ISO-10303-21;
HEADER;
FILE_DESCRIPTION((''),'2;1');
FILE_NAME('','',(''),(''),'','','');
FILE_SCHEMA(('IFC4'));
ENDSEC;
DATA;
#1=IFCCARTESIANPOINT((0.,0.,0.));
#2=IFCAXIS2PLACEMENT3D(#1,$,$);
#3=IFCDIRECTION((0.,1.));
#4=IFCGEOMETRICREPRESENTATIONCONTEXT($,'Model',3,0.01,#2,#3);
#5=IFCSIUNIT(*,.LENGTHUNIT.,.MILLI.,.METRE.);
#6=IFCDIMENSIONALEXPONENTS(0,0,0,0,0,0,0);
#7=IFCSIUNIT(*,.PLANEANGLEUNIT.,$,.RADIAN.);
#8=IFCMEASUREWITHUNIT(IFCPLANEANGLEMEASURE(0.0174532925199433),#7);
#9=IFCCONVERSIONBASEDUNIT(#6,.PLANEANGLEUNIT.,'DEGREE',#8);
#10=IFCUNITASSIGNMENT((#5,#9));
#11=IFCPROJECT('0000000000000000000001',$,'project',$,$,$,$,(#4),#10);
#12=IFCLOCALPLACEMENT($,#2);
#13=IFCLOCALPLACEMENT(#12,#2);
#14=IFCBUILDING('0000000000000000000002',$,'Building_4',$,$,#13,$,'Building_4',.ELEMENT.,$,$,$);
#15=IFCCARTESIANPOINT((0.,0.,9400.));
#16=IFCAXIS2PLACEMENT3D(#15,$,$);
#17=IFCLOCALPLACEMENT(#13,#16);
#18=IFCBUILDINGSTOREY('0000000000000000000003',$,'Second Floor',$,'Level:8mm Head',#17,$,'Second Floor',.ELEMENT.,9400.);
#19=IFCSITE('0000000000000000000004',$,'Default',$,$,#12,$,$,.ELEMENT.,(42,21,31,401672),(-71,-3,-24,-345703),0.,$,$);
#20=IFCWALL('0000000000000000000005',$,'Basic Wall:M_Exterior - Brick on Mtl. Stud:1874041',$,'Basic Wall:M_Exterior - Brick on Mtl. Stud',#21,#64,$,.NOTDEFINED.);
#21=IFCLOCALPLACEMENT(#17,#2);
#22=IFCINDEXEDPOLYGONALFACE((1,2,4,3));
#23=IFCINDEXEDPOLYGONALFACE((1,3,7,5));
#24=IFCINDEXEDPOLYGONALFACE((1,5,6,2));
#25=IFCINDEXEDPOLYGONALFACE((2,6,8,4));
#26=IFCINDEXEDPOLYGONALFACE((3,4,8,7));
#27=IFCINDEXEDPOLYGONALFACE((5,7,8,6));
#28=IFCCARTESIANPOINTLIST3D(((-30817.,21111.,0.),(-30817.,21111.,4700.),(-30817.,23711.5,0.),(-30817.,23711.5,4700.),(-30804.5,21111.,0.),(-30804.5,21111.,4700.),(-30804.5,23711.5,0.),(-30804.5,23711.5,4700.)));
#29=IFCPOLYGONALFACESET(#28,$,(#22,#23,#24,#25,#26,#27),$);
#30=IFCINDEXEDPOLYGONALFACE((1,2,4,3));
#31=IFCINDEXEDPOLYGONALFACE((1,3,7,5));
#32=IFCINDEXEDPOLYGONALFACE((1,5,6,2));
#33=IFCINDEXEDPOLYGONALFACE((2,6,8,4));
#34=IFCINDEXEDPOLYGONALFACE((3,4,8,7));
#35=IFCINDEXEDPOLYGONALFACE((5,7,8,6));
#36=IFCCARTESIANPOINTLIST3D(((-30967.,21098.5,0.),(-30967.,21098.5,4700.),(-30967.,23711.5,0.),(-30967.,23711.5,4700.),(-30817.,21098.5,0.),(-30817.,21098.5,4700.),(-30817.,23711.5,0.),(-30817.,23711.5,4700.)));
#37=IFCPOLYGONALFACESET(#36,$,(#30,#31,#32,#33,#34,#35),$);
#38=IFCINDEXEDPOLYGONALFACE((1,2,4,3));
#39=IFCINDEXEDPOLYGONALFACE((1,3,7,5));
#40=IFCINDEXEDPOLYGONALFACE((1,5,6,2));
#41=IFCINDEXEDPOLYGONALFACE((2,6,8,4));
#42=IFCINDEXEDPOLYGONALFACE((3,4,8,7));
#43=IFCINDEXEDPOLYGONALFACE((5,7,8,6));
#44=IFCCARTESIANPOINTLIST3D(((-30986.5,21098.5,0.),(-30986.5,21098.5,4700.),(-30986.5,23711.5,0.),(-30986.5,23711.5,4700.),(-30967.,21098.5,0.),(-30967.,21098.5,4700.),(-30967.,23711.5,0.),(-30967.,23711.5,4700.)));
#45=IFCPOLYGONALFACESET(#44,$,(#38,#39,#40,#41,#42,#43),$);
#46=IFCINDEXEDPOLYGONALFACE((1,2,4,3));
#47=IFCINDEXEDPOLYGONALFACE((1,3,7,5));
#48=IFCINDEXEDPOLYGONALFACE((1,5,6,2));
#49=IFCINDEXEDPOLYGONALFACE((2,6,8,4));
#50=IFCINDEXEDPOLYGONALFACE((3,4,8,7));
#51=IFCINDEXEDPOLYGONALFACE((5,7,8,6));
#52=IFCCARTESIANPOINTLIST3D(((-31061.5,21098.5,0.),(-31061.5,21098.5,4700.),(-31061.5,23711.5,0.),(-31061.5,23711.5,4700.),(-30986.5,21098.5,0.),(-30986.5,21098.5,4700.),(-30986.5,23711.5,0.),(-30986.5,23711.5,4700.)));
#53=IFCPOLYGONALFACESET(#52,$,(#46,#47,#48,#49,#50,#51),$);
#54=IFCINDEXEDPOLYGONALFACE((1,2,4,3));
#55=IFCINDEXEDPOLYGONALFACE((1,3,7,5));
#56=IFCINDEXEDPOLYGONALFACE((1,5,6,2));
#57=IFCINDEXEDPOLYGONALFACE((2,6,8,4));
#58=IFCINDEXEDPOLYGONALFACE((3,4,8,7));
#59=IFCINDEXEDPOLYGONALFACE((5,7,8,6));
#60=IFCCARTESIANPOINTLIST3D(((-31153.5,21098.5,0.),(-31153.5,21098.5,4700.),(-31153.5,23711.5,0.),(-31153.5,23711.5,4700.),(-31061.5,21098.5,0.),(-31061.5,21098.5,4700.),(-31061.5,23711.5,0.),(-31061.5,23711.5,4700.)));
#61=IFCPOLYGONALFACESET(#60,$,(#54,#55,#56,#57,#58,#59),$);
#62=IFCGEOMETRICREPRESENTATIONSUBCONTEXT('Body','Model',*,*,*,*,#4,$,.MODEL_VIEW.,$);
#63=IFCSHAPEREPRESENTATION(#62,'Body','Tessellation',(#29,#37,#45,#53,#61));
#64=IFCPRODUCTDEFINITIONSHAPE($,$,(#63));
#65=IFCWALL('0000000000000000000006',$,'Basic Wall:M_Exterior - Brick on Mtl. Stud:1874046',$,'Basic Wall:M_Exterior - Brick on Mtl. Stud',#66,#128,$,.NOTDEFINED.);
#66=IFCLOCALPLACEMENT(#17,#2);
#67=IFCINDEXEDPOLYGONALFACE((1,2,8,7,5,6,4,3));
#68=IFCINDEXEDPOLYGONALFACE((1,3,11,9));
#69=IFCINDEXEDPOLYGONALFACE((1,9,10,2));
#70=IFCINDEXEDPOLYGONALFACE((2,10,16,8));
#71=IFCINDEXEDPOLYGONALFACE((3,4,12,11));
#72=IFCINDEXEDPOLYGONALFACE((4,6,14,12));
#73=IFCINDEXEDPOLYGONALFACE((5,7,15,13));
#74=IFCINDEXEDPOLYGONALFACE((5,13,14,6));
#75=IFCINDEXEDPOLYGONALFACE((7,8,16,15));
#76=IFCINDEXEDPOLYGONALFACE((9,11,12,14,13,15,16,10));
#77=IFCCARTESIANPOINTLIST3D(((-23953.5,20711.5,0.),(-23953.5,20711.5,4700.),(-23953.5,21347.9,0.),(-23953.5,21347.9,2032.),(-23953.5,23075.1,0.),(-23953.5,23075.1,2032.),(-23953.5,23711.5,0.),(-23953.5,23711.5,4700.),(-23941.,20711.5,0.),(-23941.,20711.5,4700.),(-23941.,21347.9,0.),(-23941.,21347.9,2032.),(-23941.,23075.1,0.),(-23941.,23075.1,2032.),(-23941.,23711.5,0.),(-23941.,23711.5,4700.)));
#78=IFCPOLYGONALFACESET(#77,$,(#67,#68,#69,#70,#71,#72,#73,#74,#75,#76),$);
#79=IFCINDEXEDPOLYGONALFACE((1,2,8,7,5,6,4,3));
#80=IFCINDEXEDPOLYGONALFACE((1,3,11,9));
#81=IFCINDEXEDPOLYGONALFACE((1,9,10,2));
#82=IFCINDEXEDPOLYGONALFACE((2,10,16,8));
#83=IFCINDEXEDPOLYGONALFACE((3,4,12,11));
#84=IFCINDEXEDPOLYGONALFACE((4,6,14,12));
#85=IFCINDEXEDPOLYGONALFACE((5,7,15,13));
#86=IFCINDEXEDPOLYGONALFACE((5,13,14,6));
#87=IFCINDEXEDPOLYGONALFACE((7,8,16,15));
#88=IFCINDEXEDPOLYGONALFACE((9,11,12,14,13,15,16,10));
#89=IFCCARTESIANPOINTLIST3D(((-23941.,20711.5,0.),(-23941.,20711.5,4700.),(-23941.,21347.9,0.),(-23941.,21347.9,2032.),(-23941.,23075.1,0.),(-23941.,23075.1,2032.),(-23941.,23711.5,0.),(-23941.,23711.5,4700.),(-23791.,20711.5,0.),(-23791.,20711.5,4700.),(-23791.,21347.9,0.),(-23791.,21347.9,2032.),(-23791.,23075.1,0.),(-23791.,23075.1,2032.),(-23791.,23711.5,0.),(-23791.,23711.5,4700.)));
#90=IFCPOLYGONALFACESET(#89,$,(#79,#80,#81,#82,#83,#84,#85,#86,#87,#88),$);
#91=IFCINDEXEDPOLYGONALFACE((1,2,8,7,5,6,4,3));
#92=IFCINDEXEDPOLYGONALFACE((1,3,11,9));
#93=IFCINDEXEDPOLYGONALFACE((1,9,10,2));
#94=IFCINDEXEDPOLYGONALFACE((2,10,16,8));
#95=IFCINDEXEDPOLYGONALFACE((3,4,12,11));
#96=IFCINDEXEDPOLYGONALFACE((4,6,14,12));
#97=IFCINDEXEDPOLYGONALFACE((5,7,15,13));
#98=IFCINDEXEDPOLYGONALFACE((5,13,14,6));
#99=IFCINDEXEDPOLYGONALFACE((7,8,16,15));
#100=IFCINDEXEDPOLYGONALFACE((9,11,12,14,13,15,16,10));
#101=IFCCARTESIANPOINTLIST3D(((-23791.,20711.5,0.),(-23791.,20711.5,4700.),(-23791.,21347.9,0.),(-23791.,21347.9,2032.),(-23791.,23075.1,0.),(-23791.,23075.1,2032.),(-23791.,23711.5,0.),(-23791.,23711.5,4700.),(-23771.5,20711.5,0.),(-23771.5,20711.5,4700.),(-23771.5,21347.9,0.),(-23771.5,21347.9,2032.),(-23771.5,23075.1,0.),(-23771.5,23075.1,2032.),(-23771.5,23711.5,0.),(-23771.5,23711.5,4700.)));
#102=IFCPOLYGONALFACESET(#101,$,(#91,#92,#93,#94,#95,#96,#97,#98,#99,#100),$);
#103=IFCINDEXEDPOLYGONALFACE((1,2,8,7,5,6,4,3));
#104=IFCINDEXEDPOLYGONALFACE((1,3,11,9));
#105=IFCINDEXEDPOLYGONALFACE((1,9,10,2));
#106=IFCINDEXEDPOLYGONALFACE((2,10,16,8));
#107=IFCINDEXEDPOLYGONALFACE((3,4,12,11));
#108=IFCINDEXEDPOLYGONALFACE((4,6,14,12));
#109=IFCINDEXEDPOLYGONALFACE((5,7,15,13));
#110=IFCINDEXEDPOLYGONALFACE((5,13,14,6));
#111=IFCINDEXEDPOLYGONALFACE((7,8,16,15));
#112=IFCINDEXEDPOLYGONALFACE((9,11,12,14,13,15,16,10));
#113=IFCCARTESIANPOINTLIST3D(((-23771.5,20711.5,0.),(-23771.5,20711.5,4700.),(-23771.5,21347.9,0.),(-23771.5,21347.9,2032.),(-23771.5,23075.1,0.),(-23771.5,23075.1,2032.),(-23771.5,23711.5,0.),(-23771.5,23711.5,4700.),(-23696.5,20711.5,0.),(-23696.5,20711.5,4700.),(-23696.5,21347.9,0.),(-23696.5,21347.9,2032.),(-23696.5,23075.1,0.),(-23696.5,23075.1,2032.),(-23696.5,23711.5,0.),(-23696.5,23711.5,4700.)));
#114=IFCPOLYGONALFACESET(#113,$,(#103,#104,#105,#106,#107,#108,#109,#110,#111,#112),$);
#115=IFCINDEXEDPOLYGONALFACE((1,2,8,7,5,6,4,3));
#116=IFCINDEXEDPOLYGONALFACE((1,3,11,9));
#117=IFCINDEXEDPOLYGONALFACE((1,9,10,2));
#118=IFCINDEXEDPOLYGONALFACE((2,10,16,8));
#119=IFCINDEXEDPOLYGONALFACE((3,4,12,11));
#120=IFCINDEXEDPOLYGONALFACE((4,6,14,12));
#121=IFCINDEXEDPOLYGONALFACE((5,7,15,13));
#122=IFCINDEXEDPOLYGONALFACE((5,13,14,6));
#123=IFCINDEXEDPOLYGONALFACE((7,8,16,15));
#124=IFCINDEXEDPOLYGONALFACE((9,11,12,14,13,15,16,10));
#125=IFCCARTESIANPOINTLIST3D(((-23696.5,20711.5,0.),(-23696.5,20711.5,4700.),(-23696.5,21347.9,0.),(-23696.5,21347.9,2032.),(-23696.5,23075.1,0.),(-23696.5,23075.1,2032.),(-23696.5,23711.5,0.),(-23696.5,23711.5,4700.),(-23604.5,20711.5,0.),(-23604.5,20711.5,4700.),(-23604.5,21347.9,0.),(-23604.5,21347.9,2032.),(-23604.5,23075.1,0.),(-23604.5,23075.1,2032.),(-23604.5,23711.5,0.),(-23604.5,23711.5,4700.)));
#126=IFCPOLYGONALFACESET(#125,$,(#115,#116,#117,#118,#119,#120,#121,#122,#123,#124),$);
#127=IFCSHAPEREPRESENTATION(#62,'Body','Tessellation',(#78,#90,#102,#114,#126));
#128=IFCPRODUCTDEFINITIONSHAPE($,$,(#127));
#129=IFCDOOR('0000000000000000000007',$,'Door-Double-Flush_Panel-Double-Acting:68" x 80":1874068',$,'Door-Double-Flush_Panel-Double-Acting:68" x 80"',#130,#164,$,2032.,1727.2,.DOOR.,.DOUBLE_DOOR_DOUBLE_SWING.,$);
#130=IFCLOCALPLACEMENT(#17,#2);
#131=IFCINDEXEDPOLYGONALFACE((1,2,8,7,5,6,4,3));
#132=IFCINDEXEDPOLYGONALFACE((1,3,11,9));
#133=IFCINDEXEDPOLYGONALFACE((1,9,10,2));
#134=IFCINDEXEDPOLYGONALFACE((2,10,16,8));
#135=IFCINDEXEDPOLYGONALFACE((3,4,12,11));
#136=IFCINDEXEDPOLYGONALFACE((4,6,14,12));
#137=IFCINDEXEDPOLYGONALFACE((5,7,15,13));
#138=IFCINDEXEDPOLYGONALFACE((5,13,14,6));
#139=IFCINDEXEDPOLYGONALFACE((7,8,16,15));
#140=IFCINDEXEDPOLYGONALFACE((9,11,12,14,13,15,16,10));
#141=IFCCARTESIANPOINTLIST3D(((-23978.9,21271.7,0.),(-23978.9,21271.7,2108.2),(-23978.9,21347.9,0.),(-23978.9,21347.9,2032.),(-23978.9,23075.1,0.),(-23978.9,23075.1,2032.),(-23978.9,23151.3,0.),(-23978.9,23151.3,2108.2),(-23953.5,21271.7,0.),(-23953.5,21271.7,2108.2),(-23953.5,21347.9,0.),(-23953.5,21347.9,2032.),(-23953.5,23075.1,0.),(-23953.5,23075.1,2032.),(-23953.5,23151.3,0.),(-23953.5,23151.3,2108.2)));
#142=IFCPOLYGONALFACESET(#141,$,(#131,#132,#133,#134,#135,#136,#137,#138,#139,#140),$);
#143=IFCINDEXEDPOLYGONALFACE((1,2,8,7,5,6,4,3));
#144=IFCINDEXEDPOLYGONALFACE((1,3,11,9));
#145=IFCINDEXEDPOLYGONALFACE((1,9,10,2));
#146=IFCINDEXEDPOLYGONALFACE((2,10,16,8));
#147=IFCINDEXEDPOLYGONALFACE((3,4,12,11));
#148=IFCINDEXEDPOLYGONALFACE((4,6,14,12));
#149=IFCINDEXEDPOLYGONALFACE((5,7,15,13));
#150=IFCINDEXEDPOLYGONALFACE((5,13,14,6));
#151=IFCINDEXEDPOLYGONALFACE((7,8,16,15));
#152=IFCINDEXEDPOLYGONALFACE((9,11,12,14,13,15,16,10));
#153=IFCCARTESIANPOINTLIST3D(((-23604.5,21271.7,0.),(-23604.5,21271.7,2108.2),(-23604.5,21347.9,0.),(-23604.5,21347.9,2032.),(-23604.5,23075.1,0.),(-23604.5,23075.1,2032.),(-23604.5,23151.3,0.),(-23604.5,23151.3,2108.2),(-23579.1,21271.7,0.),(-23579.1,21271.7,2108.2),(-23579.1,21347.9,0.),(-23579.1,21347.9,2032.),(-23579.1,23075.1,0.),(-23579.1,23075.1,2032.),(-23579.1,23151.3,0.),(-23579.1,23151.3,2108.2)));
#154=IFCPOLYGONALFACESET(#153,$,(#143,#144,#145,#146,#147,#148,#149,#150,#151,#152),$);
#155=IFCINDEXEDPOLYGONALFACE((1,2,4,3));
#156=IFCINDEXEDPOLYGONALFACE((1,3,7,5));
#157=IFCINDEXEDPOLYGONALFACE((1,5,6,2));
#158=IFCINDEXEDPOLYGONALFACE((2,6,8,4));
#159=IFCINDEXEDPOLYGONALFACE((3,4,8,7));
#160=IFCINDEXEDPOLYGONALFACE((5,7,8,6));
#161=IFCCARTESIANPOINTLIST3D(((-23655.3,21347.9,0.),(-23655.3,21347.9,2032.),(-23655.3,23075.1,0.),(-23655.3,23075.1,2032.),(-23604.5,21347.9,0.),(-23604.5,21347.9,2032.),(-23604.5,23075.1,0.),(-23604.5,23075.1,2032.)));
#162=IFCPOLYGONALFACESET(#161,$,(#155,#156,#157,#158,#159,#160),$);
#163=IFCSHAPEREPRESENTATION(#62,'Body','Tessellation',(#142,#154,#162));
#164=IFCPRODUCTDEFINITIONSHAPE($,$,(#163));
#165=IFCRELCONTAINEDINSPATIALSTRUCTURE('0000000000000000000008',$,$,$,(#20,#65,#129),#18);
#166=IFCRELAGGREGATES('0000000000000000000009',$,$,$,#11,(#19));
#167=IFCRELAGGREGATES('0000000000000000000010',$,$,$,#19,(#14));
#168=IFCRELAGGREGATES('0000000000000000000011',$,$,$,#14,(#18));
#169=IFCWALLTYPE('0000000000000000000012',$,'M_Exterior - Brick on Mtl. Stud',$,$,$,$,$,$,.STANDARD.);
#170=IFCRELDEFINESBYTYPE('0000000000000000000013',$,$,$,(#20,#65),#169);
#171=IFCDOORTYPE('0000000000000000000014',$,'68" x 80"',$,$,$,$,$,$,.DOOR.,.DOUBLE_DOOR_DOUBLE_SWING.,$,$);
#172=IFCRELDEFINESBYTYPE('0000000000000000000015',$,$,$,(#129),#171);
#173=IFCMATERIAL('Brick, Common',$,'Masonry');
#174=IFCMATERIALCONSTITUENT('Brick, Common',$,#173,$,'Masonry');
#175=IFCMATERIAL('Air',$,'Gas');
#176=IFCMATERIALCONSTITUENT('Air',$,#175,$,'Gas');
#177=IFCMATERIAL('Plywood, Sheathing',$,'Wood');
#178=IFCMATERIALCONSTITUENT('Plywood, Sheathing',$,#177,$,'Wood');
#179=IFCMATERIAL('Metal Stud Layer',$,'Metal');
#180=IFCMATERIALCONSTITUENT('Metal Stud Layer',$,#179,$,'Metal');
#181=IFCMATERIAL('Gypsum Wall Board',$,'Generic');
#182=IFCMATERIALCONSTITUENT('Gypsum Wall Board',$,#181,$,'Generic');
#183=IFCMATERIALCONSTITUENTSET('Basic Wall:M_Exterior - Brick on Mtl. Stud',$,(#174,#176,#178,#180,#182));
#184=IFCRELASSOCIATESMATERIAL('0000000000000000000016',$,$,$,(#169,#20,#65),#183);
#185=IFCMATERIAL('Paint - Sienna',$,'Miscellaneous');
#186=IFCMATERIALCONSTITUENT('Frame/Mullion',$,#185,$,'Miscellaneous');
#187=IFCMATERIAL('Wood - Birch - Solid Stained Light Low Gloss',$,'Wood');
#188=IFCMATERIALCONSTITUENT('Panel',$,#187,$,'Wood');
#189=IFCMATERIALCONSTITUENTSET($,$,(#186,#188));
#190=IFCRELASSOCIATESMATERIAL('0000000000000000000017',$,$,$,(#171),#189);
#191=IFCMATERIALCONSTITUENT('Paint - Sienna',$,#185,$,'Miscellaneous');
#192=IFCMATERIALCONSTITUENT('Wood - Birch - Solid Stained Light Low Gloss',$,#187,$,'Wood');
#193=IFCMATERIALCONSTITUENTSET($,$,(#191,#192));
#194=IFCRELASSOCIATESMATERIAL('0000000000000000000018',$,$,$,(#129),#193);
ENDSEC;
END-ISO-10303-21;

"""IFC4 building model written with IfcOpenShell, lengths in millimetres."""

from ifc_helpers import new_model, entity, si_unit, converted_unit, direction, frame, origin, place, context, subcontext, project, spatial, indexed_curve, outline, extrude, source, transform, mapped, material, constituent, constituent_set, type_object, type_shapes, element, fill, save


model = new_model("IFC4")

# Units and contexts
model_context = context("Model", 3, precision=0.01, world=origin(), true_north=direction((0.0, 1.0)))
body_context = subcontext(model_context, "Body", "Model", "MODEL_VIEW")
ifc_project = project(units=[si_unit("LENGTHUNIT", "METRE", prefix="MILLI"), converted_unit("PLANEANGLEUNIT", "DEGREE", entity("IfcPlaneAngleMeasure", 0.0174532925199433), si_unit("PLANEANGLEUNIT", "RADIAN"), dimensions=[0, 0, 0, 0, 0, 0, 0])], contexts=[model_context])

# Site, building, storey
site_placement = place(None, origin())
site = spatial("IfcSite", under=ifc_project, at=site_placement, Name="Default", CompositionType="ELEMENT", RefLatitude=(42, 21, 31, 401672), RefLongitude=(-71, -3, -24, -345703), RefElevation=0.0)
building_placement = place(site_placement, origin())
building = spatial("IfcBuilding", under=site, at=building_placement, Name="Building_4", LongName="Building_4", CompositionType="ELEMENT")
storey_placement = place(building_placement, frame((0.0, 0.0, 9400.0)))
storey = spatial("IfcBuildingStorey", under=building, at=storey_placement, Name="Second Floor", ObjectType="Level:8mm Head", LongName="Second Floor", CompositionType="ELEMENT", Elevation=9400.0)

# Shared definitions
ifc_material_1 = material(Name="Brick, Common", Category="Masonry")
ifc_constituent_1 = constituent(ifc_material_1, Name="Brick, Common", Category="Masonry")
ifc_material_2 = material(Name="Air", Category="Gas")
ifc_constituent_2 = constituent(ifc_material_2, Name="Air", Category="Gas")
ifc_material_3 = material(Name="Plywood, Sheathing", Category="Wood")
ifc_constituent_3 = constituent(ifc_material_3, Name="Plywood, Sheathing", Category="Wood")
ifc_material_4 = material(Name="Metal Stud Layer", Category="Metal")
ifc_constituent_4 = constituent(ifc_material_4, Name="Metal Stud Layer", Category="Metal")
ifc_material_5 = material(Name="Gypsum Wall Board", Category="Generic")
ifc_constituent_5 = constituent(ifc_material_5, Name="Gypsum Wall Board", Category="Generic")
ifc_constituent_set_1 = constituent_set(constituents=[ifc_constituent_1, ifc_constituent_2, ifc_constituent_3, ifc_constituent_4, ifc_constituent_5], Name="Basic Wall:M_Exterior - Brick on Mtl. Stud")
wall_type_1 = type_object("IfcWallType", Name="M_Exterior - Brick on Mtl. Stud", PredefinedType="STANDARD", material=ifc_constituent_set_1)

# Wall
wall_1_placement = place(storey_placement, frame((-30979.0, 21111.0, 0.0), z_axis=(0.0, 0.0, 1.0), x_axis=(0.0, 1.0, 0.0)))
element("IfcWall", 1, at=wall_1_placement, inside=storey, type_object=wall_type_1, material=ifc_constituent_set_1, Name="Basic Wall:M_Exterior - Brick on Mtl. Stud:1874041", ObjectType="Basic Wall:M_Exterior - Brick on Mtl. Stud", PredefinedType="NOTDEFINED", context=body_context, shape_type="SweptSolid", body=[
    extrude(outline(indexed_curve([(-6.3, -1300.2), (6.2, -1300.2), (6.2, 1300.2), (-6.2, 1300.2), (-6.3, -1300.2)], self_intersect=False)), frame((1300.2, -168.2, 0.0), z_axis=(0.0, 0.0, 1.0), x_axis=(0.0, 1.0, 0.0)), (0.0, 0.0, 1.0), 4700.0),
    extrude(outline(indexed_curve([(-1306.5, -75.0), (1306.5, -75.0), (1306.5, 75.0), (-1306.5, 75.0), (-1306.5, -75.0)], self_intersect=False)), frame((1294.0, -87.0, 0.0)), (0.0, 0.0, 1.0), 4700.0),
    extrude(outline(indexed_curve([(-1306.5, -9.7), (1306.5, -9.7), (1306.5, 9.7), (-1306.5, 9.7), (-1306.5, -9.7)], self_intersect=False)), frame((1294.0, -2.3, 0.0)), (0.0, 0.0, 1.0), 4700.0),
    extrude(outline(indexed_curve([(-1306.5, -37.5), (1306.5, -37.5), (1306.5, 37.5), (-1306.5, 37.5), (-1306.5, -37.5)], self_intersect=False)), frame((1294.0, 45.0, 0.0)), (0.0, 0.0, 1.0), 4700.0),
    extrude(outline(indexed_curve([(-46.0, -1306.5), (46.0, -1306.5), (46.0, 1306.5), (-46.0, 1306.5), (-46.0, -1306.5)], self_intersect=False)), frame((1294.0, 128.5, 0.0), z_axis=(0.0, 0.0, 1.0), x_axis=(0.0, -1.0, 0.0)), (0.0, 0.0, 1.0), 4700.0),
])

# Wall, opening, door
wall_2_placement = place(storey_placement, frame((-23779.0, 23711.5, 0.0), z_axis=(0.0, 0.0, 1.0), x_axis=(0.0, -1.0, 0.0)))
wall_2 = element("IfcWall", 2, at=wall_2_placement, inside=storey, type_object=wall_type_1, material=ifc_constituent_set_1, Name="Basic Wall:M_Exterior - Brick on Mtl. Stud:1874046", ObjectType="Basic Wall:M_Exterior - Brick on Mtl. Stud", PredefinedType="NOTDEFINED", context=body_context, shape_type="SweptSolid", body=[
    extrude(outline(indexed_curve([(-1500.0, -1683.0), (-863.6, -1683.0), (-863.6, 349.0), (863.6, 349.0), (863.6, -1683.0), (1500.0, -1683.0), (1500.0, 3017.0), (-1500.0, 3017.0), (-1500.0, -1683.0)], self_intersect=False)), frame((1500.0, -174.5, 1683.0), z_axis=(0.0, 1.0, 0.0), x_axis=(-1.0, 0.0, 0.0)), (0.0, 0.0, 1.0), 12.5),
    extrude(outline(indexed_curve([(-1683.0, -863.6), (-1683.0, -1500.0), (3017.0, -1500.0), (3017.0, 1500.0), (-1683.0, 1500.0), (-1683.0, 863.6), (349.0, 863.6), (349.0, -863.6), (-1683.0, -863.6)], self_intersect=False)), frame((1500.0, -162.0, 1683.0), z_axis=(0.0, -1.0, 0.0), x_axis=(0.0, 0.0, 1.0)), (0.0, 0.0, -1.0), 150.0),
    extrude(outline(indexed_curve([(-1683.0, -863.6), (-1683.0, -1500.0), (3017.0, -1500.0), (3017.0, 1500.0), (-1683.0, 1500.0), (-1683.0, 863.6), (349.0, 863.6), (349.0, -863.6), (-1683.0, -863.6)], self_intersect=False)), frame((1500.0, -12.0, 1683.0), z_axis=(0.0, -1.0, 0.0), x_axis=(0.0, 0.0, 1.0)), (0.0, 0.0, -1.0), 19.5),
    extrude(outline(indexed_curve([(-1683.0, -863.6), (-1683.0, -1500.0), (3017.0, -1500.0), (3017.0, 1500.0), (-1683.0, 1500.0), (-1683.0, 863.6), (349.0, 863.6), (349.0, -863.6), (-1683.0, -863.6)], self_intersect=False)), frame((1500.0, 7.5, 1683.0), z_axis=(0.0, -1.0, 0.0), x_axis=(0.0, 0.0, 1.0)), (0.0, 0.0, -1.0), 75.0),
    extrude(outline(indexed_curve([(-1683.0, -863.6), (-1683.0, -1500.0), (3017.0, -1500.0), (3017.0, 1500.0), (-1683.0, 1500.0), (-1683.0, 863.6), (349.0, 863.6), (349.0, -863.6), (-1683.0, -863.6)], self_intersect=False)), frame((1500.0, 82.5, 1683.0), z_axis=(0.0, -1.0, 0.0), x_axis=(0.0, 0.0, 1.0)), (0.0, 0.0, -1.0), 92.0),
])
opening_1_placement = place(wall_2_placement, frame((636.4, -174.5, 0.0)))
opening_1 = element("IfcOpeningElement", 3, at=opening_1_placement, cuts=wall_2, PredefinedType="OPENING", context=body_context, shape_type="SweptSolid", body=[
    extrude(outline(indexed_curve([(0.0, 1727.2), (0.0, 0.0), (2032.0, 0.0), (2032.0, 1727.2), (0.0, 1727.2)], self_intersect=False)), frame((0.0, 0.0, 0.0), z_axis=(0.0, 1.0, 0.0), x_axis=(0.0, 0.0, 1.0)), (0.0, 0.0, 1.0), 349.0),
])
ifc_material_6 = material(Name="Paint - Sienna", Category="Miscellaneous")
ifc_constituent_6 = constituent(ifc_material_6, Name="Paint - Sienna", Category="Miscellaneous")
ifc_material_7 = material(Name="Wood - Birch - Solid Stained Light Low Gloss", Category="Wood")
ifc_constituent_7 = constituent(ifc_material_7, Name="Wood - Birch - Solid Stained Light Low Gloss", Category="Wood")
ifc_constituent_set_2 = constituent_set(constituents=[ifc_constituent_6, ifc_constituent_7])
ifc_constituent_8 = constituent(ifc_material_6, Name="Frame/Mullion", Category="Miscellaneous")
ifc_constituent_9 = constituent(ifc_material_7, Name="Panel", Category="Wood")
ifc_constituent_set_3 = constituent_set(constituents=[ifc_constituent_8, ifc_constituent_9])
door_type = type_object("IfcDoorType", Name="68\" x 80\"", OperationType="DOUBLE_DOOR_DOUBLE_SWING", PredefinedType="DOOR", material=ifc_constituent_set_3)
shared_shape_1 = source(origin(), body_context, "Body", "SweptSolid", [
    extrude(outline(indexed_curve([(-997.0, 863.6), (1035.0, 863.6), (1035.0, 939.8), (-1073.2, 939.8), (-1073.2, -939.8), (1035.0, -939.8), (1035.0, -863.6), (-997.0, -863.6), (-997.0, 863.6)], self_intersect=False)), frame((863.6, -25.4, 1035.0), z_axis=(0.0, 1.0, 0.0), x_axis=(0.0, 0.0, -1.0)), (0.0, 0.0, 1.0), 25.4),
    extrude(outline(indexed_curve([(-939.8, -1073.2), (939.8, -1073.2), (939.8, 1035.0), (863.6, 1035.0), (863.6, -997.0), (-863.6, -997.0), (-863.6, 1035.0), (-939.8, 1035.0), (-939.8, -1073.2)], self_intersect=False)), frame((863.6, 349.0, 1035.0), z_axis=(0.0, 1.0, 0.0), x_axis=(1.0, 0.0, 0.0)), (0.0, 0.0, 1.0), 25.4),
    extrude(outline(indexed_curve([(-25.4, -863.6), (25.4, -863.6), (25.4, 863.6), (-25.4, 863.6), (-25.4, -863.6)], self_intersect=False)), frame((863.6, 323.6, 0.0), z_axis=(0.0, 0.0, 1.0), x_axis=(0.0, -1.0, 0.0)), (0.0, 0.0, 1.0), 2032.0),
])
type_shapes(door_type, [shared_shape_1])
door_placement = place(opening_1_placement, origin())
door = element("IfcDoor", 4, at=door_placement, inside=storey, type_object=door_type, material=ifc_constituent_set_2, Name="Door-Double-Flush_Panel-Double-Acting:68\" x 80\":1874068", ObjectType="Door-Double-Flush_Panel-Double-Acting:68\" x 80\"", OperationType="DOUBLE_DOOR_DOUBLE_SWING", OverallHeight=2032.0, OverallWidth=1727.2, PredefinedType="DOOR", context=body_context, shape_type="MappedRepresentation", body=[
    mapped(shared_shape_1, transform((0.0, 0.0, 0.0), scale=1.0)),
])
fill(opening_1, door)

save(model, "model.ifc")
